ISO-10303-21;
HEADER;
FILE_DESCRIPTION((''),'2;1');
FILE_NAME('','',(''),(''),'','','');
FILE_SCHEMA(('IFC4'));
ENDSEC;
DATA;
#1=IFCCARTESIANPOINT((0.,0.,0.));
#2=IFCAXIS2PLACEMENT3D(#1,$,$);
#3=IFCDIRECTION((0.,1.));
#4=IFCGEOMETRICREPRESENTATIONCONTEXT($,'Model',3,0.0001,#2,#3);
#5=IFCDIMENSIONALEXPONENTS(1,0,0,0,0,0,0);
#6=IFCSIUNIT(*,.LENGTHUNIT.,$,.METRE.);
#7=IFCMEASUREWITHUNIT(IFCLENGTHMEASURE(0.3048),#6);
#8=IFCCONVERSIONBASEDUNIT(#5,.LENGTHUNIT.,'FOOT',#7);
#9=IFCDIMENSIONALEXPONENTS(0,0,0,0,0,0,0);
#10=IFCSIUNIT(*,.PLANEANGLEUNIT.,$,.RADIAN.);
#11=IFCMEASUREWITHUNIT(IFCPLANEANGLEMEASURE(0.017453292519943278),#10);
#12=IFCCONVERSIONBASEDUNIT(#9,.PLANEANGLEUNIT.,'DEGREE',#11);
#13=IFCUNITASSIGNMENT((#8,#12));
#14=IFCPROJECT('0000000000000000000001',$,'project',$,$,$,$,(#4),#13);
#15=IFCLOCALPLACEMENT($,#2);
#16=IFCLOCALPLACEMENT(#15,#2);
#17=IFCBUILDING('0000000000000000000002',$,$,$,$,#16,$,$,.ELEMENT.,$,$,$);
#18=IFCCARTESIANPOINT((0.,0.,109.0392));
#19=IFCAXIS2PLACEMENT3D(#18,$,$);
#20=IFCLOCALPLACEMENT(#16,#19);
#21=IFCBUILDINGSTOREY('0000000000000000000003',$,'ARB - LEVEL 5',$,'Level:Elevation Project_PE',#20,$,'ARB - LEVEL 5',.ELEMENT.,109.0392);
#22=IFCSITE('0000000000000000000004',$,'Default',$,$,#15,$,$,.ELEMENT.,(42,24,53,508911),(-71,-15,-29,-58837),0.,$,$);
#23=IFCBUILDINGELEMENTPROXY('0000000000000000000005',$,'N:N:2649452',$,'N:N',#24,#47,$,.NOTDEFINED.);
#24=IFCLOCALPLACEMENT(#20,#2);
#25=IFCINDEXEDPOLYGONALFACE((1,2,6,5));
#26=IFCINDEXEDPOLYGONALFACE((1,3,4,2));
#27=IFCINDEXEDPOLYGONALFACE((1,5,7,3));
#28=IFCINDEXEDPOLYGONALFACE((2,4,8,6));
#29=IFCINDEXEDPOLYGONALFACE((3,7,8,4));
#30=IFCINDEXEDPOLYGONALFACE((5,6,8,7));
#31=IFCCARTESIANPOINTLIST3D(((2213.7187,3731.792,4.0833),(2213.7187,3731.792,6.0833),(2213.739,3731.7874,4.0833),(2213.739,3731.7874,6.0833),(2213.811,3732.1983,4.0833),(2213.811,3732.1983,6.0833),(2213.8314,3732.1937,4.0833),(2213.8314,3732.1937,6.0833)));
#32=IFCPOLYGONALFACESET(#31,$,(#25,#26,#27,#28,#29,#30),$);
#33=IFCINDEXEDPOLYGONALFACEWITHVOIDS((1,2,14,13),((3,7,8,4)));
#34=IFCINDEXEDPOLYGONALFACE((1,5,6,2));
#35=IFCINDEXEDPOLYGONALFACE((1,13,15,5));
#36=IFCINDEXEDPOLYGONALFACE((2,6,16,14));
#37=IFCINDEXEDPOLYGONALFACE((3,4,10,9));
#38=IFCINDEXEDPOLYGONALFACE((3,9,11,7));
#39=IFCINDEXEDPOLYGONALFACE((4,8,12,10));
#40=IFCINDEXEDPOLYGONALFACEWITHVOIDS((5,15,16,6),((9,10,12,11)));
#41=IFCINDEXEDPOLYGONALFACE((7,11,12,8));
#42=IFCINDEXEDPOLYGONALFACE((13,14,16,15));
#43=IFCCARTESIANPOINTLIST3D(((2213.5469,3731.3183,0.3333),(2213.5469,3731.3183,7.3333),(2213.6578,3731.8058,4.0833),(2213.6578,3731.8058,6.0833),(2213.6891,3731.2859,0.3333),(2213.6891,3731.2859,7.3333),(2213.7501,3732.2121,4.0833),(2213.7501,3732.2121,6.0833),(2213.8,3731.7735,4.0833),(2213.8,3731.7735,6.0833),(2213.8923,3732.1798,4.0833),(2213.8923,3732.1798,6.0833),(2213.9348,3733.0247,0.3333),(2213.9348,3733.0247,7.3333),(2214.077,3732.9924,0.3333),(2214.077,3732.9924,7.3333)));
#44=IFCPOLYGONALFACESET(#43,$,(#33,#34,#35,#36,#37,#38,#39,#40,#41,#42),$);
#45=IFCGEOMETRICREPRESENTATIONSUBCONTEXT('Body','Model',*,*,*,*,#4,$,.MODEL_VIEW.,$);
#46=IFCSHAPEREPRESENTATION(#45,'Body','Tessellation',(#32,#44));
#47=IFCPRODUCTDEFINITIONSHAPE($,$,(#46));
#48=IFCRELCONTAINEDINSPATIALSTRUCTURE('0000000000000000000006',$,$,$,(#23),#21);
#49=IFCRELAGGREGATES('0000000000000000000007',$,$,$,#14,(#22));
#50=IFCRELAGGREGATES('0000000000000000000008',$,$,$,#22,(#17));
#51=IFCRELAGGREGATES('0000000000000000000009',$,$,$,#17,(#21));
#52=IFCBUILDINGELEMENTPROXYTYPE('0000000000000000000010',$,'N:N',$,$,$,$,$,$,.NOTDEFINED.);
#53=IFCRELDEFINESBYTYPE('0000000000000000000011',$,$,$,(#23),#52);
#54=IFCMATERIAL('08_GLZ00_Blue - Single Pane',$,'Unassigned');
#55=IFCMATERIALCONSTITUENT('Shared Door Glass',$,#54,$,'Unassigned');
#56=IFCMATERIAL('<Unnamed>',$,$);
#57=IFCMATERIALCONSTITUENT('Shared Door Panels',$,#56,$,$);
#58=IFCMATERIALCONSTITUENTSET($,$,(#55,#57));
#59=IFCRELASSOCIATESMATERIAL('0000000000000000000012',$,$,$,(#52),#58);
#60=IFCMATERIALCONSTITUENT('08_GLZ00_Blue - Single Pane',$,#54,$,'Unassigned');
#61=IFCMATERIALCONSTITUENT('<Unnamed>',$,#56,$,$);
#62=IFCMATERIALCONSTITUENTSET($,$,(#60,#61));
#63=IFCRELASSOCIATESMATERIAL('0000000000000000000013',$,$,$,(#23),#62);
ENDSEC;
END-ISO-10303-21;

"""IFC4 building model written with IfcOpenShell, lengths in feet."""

from ifc_helpers import new_model, entity, si_unit, converted_unit, direction, frame, origin, place, context, subcontext, project, spatial, indexed_curve, outline, extrude, source, transform, mapped, material, constituent, constituent_set, type_object, type_shapes, element, save


model = new_model("IFC4")

# Units and contexts
model_context = context("Model", 3, precision=0.0001, world=origin(), true_north=direction((0.0, 1.0)))
body_context = subcontext(model_context, "Body", "Model", "MODEL_VIEW")
ifc_project = project(units=[converted_unit("LENGTHUNIT", "FOOT", entity("IfcLengthMeasure", 0.3048), si_unit("LENGTHUNIT", "METRE"), dimensions=[1, 0, 0, 0, 0, 0, 0]), converted_unit("PLANEANGLEUNIT", "DEGREE", entity("IfcPlaneAngleMeasure", 0.017453292519943278), si_unit("PLANEANGLEUNIT", "RADIAN"), dimensions=[0, 0, 0, 0, 0, 0, 0])], contexts=[model_context])

# Site, building, storey
site_placement = place(None, origin())
site = spatial("IfcSite", under=ifc_project, at=site_placement, Name="Default", CompositionType="ELEMENT", RefLatitude=(42, 24, 53, 508911), RefLongitude=(-71, -15, -29, -58837), RefElevation=0.0)
building_placement = place(site_placement, origin())
building = spatial("IfcBuilding", under=site, at=building_placement, CompositionType="ELEMENT")
storey_placement = place(building_placement, frame((0.0, 0.0, 109.0392)))
storey = spatial("IfcBuildingStorey", under=building, at=storey_placement, Name="ARB - LEVEL 5", ObjectType="Level:Elevation Project_PE", LongName="ARB - LEVEL 5", CompositionType="ELEMENT", Elevation=109.0392)

# Shared definitions
ifc_material_1 = material(Name="<Unnamed>")

# Building element proxy
ifc_material_2 = material(Name="08_GLZ00_Blue - Single Pane", Category="Unassigned")
ifc_constituent_1 = constituent(ifc_material_2, Name="08_GLZ00_Blue - Single Pane", Category="Unassigned")
ifc_constituent_2 = constituent(ifc_material_1, Name="<Unnamed>")
ifc_constituent_set_1 = constituent_set(constituents=[ifc_constituent_1, ifc_constituent_2])
ifc_constituent_3 = constituent(ifc_material_2, Name="Shared Door Glass", Category="Unassigned")
ifc_constituent_4 = constituent(ifc_material_1, Name="Shared Door Panels")
ifc_constituent_set_2 = constituent_set(constituents=[ifc_constituent_3, ifc_constituent_4])
building_element_proxy_type_1 = type_object("IfcBuildingElementProxyType", Name="N:N", PredefinedType="NOTDEFINED", material=ifc_constituent_set_2)
shared_shape_1 = source(origin(), body_context, "Body", "SweptSolid", [
    extrude(outline(indexed_curve([(-0.0104, -0.2083), (0.0104, -0.2083), (0.0104, 0.2083), (-0.0104, 0.2083), (-0.0104, -0.2083)], self_intersect=False)), frame((-0.4525, 3.25, 3.75), z_axis=(0.0, 0.0, 1.0), x_axis=(0.0, 1.0, 0.0)), (0.0, 0.0, 1.0), 2.0),
    extrude(outline(indexed_curve([(-3.5, -0.875), (3.5, -0.875), (3.5, 0.875), (-3.5, 0.875), (-3.5, -0.875)], self_intersect=False), holes=[indexed_curve([(-2.25, -0.0417), (-2.25, 0.375), (-0.25, 0.375), (-0.25, -0.0417), (-2.25, -0.0417)], self_intersect=False)]), frame((-0.2859, 3.1771, 3.5), z_axis=(0.0, 1.0, 0.0), x_axis=(0.0, 0.0, -1.0)), (0.0, 0.0, 1.0), 0.1458),
])
type_shapes(building_element_proxy_type_1, [shared_shape_1])
proxy_1_placement = place(storey_placement, frame((2217.0445, 3731.7138, 0.3333), z_axis=(0.0, 0.0, 1.0), x_axis=(0.221622, 0.975133, 0.0)))
element("IfcBuildingElementProxy", 1, at=proxy_1_placement, inside=storey, type_object=building_element_proxy_type_1, material=ifc_constituent_set_1, Name="N:N:2649452", ObjectType="N:N", PredefinedType="NOTDEFINED", context=body_context, shape_type="MappedRepresentation", body=[
    mapped(shared_shape_1, transform((0.0, 0.0, 0.0), scale=1.0)),
])

save(model, "model.ifc")
